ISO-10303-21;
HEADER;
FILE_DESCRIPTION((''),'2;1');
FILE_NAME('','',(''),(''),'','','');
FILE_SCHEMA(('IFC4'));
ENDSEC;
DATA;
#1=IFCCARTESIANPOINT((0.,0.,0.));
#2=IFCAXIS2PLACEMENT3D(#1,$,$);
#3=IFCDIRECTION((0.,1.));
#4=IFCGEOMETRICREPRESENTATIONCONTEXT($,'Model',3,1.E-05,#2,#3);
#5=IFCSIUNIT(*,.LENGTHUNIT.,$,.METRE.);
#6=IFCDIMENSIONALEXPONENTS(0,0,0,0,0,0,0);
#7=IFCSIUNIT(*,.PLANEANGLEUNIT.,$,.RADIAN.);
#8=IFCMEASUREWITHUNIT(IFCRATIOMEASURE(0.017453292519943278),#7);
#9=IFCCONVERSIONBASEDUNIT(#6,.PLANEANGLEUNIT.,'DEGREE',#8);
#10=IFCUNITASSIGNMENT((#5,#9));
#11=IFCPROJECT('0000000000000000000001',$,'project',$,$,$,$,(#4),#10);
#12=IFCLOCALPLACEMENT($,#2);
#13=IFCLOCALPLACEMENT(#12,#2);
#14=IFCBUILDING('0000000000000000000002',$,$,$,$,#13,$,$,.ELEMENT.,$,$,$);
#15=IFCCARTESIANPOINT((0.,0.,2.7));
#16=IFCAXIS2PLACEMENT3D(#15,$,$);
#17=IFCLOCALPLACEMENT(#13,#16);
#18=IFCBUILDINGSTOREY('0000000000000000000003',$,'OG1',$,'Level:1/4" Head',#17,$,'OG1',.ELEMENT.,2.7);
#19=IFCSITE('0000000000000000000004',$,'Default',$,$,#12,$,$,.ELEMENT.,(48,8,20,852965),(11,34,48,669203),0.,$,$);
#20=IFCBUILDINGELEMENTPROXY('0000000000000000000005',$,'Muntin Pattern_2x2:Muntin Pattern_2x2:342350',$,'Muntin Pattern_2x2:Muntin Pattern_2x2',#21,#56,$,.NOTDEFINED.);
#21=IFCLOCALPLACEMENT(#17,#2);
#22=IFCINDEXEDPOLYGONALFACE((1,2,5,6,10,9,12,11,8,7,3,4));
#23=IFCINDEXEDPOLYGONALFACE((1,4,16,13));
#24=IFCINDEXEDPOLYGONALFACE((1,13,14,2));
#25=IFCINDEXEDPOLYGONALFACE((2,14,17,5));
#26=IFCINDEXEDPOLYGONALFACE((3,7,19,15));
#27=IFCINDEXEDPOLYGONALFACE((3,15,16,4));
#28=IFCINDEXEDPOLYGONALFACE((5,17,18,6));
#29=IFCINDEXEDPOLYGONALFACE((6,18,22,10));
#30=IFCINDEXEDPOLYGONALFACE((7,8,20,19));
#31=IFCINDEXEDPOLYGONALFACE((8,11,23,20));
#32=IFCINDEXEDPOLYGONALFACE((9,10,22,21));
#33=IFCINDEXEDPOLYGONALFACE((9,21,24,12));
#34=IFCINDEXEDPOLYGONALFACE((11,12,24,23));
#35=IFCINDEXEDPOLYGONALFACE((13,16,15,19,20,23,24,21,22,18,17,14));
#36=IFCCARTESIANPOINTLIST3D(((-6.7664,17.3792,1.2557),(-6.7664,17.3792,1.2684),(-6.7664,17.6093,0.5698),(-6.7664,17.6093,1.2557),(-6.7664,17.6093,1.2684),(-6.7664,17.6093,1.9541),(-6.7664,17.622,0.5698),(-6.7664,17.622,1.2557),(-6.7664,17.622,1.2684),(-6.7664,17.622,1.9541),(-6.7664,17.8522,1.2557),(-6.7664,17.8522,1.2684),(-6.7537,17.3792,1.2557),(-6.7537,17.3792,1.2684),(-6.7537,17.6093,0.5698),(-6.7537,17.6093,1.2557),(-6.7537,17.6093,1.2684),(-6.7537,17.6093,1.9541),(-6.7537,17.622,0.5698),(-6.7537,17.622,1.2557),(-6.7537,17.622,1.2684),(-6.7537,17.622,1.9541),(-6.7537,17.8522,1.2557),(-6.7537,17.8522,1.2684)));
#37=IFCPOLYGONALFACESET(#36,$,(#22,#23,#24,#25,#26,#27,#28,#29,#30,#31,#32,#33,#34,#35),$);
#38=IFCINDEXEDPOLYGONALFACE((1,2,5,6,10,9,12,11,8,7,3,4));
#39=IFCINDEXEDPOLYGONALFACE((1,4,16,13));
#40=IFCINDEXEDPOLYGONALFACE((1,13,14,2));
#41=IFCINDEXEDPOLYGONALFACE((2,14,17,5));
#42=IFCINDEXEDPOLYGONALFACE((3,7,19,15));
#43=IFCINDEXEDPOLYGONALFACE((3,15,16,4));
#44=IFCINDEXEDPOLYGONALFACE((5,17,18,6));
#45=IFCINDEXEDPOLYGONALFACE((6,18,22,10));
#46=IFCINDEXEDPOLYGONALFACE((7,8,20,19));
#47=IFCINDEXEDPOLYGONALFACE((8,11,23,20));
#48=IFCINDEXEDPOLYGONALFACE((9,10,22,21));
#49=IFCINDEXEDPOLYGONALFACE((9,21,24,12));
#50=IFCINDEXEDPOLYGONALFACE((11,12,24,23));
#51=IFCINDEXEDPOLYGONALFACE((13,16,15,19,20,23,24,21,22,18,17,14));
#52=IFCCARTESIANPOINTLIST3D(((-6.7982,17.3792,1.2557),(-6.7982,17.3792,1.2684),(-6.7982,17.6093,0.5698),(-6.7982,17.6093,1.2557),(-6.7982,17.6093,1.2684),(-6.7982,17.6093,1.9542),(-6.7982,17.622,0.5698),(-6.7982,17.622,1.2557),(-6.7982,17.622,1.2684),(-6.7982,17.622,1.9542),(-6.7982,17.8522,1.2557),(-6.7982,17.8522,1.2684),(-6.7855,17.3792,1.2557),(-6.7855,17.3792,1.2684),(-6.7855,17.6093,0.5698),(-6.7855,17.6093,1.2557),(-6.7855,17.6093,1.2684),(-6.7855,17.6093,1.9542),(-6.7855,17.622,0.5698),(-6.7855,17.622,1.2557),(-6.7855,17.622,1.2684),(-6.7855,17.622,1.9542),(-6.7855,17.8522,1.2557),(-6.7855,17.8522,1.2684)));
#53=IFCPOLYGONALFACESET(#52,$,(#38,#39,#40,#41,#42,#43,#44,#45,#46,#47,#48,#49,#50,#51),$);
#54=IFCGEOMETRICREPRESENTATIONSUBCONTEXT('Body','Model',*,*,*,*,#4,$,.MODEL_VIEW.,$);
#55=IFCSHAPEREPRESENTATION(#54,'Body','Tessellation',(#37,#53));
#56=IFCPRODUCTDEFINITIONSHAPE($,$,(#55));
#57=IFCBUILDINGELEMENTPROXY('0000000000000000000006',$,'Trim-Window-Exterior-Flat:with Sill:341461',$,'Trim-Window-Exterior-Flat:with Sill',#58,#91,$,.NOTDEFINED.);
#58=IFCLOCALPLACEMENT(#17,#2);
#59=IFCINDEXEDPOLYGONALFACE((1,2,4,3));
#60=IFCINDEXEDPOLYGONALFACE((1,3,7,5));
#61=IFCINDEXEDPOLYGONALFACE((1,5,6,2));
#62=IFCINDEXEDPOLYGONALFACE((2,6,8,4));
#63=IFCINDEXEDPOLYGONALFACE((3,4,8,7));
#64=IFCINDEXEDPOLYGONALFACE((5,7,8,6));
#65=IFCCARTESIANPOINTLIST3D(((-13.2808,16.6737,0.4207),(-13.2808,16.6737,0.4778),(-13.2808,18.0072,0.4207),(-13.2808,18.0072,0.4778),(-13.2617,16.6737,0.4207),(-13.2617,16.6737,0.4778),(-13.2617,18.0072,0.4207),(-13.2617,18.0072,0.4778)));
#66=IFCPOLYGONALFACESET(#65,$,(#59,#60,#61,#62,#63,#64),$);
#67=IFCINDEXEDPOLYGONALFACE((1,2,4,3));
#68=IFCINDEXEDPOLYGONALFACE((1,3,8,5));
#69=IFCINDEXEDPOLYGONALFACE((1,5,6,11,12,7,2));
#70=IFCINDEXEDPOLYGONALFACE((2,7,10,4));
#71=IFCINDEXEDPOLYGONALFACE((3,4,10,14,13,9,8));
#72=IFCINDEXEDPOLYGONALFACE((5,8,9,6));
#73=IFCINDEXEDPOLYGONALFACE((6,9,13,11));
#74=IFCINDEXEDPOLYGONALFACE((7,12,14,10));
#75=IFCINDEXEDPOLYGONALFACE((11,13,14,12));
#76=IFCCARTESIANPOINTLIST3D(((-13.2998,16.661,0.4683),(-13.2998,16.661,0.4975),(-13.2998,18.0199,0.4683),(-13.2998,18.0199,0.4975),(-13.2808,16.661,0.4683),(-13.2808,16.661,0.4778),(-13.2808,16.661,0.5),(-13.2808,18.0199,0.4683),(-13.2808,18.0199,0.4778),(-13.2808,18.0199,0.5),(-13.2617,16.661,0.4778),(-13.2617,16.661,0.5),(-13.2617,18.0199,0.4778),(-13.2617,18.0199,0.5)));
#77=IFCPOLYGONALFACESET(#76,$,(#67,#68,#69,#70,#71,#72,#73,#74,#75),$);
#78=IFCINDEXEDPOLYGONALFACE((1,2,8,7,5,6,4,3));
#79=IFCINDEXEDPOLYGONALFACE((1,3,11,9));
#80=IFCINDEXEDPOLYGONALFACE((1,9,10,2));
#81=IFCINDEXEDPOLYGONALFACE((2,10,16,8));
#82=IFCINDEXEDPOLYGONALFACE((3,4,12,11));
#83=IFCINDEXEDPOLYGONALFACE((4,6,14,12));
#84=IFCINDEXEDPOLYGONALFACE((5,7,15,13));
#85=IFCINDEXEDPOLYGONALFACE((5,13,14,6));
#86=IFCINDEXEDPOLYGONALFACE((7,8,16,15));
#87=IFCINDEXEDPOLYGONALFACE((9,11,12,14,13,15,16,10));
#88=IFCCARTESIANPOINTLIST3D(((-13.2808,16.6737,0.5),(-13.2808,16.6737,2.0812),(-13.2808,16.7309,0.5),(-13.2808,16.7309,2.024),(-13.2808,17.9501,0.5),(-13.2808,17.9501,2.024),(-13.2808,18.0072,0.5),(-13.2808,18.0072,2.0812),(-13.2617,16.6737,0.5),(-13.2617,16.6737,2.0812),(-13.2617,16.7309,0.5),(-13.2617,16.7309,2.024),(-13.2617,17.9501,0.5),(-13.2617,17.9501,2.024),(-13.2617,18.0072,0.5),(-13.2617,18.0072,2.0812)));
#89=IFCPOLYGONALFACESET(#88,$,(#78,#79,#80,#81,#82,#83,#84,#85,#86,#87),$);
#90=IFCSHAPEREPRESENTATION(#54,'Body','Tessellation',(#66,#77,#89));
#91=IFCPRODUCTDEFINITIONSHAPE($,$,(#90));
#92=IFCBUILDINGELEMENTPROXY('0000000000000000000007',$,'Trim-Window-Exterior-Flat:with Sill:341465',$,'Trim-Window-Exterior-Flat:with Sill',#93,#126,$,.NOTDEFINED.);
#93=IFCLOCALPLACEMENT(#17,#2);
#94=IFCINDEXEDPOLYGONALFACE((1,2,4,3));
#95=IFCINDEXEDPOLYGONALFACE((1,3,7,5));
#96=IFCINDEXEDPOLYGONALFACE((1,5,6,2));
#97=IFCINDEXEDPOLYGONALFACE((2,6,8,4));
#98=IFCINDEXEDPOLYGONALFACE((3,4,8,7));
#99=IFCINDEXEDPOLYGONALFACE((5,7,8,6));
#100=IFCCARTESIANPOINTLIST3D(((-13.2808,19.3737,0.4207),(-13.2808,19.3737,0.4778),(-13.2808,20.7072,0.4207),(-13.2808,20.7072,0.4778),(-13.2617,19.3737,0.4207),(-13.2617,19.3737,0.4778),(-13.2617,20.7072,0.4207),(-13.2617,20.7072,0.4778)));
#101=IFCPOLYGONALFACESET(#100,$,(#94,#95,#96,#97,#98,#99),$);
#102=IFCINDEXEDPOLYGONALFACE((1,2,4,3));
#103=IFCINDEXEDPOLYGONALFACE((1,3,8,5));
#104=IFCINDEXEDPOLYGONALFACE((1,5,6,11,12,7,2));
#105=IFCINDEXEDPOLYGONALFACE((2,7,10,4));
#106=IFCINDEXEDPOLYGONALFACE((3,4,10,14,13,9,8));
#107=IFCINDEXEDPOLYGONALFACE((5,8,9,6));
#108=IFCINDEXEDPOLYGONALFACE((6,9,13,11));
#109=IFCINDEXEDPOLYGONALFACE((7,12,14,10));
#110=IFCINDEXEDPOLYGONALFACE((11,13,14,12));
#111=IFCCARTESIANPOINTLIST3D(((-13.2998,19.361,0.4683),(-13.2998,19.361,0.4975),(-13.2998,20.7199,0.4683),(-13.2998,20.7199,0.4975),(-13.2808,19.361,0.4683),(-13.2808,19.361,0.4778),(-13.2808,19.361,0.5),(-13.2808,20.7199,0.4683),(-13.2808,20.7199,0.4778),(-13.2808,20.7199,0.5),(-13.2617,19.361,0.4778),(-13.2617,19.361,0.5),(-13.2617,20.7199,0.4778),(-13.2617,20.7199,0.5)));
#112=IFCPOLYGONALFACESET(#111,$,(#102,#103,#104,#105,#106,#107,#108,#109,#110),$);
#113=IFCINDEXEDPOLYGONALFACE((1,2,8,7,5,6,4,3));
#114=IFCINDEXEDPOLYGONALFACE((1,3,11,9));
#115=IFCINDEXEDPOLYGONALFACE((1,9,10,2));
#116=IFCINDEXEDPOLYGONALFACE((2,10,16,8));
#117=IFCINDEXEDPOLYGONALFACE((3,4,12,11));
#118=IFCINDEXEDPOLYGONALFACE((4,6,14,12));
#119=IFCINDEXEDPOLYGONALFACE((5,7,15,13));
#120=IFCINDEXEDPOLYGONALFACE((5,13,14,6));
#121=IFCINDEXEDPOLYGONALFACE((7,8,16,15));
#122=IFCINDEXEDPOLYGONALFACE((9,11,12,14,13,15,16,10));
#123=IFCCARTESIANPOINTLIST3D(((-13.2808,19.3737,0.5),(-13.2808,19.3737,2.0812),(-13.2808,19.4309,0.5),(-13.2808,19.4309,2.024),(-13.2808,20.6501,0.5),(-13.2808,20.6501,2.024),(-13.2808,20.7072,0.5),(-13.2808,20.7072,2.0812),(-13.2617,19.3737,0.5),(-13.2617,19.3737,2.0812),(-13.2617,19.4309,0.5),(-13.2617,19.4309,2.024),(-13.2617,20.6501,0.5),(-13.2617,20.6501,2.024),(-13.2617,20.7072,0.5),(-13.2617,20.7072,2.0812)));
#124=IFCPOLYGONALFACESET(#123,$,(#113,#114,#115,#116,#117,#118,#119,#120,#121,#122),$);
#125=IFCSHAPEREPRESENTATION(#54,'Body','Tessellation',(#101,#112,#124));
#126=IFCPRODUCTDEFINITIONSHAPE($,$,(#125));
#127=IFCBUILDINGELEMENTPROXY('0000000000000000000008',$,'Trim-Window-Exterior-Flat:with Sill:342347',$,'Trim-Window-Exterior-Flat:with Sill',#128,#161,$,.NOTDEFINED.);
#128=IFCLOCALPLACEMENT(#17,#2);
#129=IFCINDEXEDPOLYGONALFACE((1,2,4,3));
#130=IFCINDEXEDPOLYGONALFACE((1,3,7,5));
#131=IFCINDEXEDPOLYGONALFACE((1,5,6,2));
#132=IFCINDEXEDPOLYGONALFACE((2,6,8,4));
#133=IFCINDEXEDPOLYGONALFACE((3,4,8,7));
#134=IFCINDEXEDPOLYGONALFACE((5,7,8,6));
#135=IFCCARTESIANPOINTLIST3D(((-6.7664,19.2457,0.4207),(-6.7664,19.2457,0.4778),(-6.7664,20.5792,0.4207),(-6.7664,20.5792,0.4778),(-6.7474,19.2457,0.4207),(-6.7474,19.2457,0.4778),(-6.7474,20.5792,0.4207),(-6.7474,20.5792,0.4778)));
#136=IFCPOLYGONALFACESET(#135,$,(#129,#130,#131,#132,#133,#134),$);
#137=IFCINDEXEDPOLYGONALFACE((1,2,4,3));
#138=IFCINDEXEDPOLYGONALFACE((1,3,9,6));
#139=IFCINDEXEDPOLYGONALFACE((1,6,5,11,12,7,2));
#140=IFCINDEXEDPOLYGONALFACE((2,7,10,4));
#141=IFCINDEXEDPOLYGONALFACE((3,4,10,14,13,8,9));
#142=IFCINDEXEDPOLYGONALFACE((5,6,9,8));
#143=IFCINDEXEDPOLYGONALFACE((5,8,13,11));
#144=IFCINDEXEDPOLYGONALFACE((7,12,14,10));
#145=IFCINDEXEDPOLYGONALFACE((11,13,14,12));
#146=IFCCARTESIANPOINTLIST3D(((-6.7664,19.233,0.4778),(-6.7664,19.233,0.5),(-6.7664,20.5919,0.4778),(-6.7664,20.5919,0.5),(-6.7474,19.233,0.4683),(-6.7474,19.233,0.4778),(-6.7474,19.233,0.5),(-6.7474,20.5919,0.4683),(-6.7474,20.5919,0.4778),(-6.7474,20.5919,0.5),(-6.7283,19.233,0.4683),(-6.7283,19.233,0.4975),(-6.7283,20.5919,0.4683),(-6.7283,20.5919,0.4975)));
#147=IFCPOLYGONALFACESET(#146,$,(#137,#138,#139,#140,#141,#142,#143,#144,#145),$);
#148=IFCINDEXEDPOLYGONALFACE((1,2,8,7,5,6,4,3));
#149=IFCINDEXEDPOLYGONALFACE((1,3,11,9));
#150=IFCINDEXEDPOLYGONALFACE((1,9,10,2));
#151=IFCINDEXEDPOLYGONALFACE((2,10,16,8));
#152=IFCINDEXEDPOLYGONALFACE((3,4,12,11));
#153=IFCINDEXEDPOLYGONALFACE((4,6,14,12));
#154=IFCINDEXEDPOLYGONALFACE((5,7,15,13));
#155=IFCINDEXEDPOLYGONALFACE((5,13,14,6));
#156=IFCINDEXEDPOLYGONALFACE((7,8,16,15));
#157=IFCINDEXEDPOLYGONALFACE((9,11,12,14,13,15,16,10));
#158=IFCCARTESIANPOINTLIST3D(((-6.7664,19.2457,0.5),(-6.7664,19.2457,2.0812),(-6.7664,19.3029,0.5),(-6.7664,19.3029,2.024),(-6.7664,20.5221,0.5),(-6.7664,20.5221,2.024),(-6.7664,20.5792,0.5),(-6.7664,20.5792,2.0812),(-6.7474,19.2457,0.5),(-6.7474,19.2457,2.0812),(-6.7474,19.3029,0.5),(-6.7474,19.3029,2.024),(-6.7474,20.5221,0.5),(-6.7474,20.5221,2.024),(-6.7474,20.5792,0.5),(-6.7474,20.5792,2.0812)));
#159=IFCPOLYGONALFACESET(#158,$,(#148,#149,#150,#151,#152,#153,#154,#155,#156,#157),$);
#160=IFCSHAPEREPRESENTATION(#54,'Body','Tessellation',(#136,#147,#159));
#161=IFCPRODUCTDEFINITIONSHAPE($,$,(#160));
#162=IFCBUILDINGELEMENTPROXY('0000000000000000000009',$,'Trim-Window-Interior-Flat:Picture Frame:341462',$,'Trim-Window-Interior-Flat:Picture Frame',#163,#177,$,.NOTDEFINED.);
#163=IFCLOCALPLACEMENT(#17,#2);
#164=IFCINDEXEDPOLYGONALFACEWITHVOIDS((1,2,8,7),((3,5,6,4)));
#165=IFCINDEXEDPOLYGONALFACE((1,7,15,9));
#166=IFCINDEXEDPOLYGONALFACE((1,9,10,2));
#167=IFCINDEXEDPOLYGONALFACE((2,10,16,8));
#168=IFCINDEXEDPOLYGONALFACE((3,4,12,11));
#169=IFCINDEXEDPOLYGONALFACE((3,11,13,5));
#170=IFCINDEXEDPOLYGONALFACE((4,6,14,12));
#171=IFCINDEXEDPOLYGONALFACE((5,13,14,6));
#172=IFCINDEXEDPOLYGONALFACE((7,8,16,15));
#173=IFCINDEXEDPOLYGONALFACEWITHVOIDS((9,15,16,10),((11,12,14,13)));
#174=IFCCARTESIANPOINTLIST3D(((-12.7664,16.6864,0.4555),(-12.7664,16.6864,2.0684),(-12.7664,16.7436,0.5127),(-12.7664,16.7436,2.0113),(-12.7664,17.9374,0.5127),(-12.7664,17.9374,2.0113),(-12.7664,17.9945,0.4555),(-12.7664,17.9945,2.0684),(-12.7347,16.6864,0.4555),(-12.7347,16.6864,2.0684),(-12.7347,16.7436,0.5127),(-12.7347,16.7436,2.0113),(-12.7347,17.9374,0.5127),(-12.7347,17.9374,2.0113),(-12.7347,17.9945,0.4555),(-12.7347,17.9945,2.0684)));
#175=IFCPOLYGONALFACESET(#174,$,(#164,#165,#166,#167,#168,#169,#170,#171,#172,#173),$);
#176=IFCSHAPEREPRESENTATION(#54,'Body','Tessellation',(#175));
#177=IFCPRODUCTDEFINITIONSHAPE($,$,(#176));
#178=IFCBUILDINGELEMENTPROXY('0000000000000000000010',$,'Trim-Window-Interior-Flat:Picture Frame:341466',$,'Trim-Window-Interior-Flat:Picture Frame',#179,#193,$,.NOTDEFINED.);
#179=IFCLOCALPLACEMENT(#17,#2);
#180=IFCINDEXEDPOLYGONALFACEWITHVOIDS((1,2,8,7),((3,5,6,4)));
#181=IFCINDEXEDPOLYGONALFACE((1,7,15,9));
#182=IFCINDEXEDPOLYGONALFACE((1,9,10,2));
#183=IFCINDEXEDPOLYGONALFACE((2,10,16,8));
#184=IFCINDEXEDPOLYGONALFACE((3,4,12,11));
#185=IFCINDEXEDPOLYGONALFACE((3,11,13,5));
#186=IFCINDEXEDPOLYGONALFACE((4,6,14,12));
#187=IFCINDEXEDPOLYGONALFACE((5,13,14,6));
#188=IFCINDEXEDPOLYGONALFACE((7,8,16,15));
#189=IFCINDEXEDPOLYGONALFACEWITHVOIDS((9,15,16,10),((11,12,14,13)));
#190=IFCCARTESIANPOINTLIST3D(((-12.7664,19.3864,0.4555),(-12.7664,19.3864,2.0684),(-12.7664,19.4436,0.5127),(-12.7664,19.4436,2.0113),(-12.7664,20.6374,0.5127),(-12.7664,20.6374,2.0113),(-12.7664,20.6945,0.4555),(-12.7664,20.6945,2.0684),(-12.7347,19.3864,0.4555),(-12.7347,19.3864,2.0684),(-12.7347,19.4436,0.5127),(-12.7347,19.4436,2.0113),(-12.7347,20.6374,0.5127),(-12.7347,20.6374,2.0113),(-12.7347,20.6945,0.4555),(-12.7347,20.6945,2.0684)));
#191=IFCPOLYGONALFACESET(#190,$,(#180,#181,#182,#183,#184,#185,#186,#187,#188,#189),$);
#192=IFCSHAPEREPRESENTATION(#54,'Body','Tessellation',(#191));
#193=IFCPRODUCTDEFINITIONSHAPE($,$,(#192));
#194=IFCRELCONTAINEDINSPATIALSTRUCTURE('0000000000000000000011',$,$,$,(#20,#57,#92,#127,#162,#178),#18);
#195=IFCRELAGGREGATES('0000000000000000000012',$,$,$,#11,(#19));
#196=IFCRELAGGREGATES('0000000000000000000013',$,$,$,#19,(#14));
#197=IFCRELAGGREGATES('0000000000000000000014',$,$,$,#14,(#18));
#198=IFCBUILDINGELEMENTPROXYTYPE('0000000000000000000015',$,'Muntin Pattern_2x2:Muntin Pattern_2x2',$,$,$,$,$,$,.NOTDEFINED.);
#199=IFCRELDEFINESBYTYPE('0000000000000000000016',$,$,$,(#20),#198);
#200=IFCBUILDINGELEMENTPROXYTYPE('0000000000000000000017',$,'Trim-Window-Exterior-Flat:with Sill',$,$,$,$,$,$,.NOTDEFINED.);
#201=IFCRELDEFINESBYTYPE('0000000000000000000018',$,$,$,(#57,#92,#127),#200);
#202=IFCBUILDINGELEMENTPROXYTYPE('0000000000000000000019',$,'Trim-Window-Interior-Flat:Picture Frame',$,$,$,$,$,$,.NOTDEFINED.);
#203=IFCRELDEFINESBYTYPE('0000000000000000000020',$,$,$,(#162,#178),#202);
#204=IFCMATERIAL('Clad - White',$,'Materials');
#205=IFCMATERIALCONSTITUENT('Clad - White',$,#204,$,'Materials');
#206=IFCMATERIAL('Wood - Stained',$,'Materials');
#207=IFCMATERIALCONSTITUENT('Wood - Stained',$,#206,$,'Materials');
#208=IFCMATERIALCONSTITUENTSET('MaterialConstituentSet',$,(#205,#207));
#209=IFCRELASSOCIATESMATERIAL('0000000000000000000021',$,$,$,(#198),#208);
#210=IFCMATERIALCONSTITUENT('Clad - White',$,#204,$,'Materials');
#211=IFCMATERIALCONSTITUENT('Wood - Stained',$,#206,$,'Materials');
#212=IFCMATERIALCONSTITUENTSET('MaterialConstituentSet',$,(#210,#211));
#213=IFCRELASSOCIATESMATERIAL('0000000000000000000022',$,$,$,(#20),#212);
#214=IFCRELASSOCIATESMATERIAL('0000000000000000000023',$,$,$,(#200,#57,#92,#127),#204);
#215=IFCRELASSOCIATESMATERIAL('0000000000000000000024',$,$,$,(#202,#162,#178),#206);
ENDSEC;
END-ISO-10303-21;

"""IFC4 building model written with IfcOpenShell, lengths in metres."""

from ifc_helpers import new_model, entity, si_unit, converted_unit, direction, frame, origin, place, context, subcontext, project, spatial, indexed_curve, outline, extrude, source, transform, mapped, material, constituent, constituent_set, type_object, type_shapes, element, save


model = new_model("IFC4")

# Units and contexts
model_context = context("Model", 3, precision=1e-05, world=origin(), true_north=direction((0.0, 1.0)))
body_context = subcontext(model_context, "Body", "Model", "MODEL_VIEW")
ifc_project = project(units=[si_unit("LENGTHUNIT", "METRE"), converted_unit("PLANEANGLEUNIT", "DEGREE", entity("IfcRatioMeasure", 0.017453292519943278), si_unit("PLANEANGLEUNIT", "RADIAN"), dimensions=[0, 0, 0, 0, 0, 0, 0])], contexts=[model_context])

# Site, building, storey
site_placement = place(None, origin())
site = spatial("IfcSite", under=ifc_project, at=site_placement, Name="Default", CompositionType="ELEMENT", RefLatitude=(48, 8, 20, 852965), RefLongitude=(11, 34, 48, 669203), RefElevation=0.0)
building_placement = place(site_placement, origin())
building = spatial("IfcBuilding", under=site, at=building_placement, CompositionType="ELEMENT")
storey_placement = place(building_placement, frame((0.0, 0.0, 2.7)))
storey = spatial("IfcBuildingStorey", under=building, at=storey_placement, Name="OG1", ObjectType="Level:1/4\" Head", LongName="OG1", CompositionType="ELEMENT", Elevation=2.7)

# Building element proxies
ifc_material_1 = material(Name="Clad - White", Category="Materials")
ifc_material_2 = material(Name="Wood - Stained", Category="Materials")
ifc_constituent_1 = constituent(ifc_material_1, Name="Clad - White", Category="Materials")
ifc_constituent_2 = constituent(ifc_material_2, Name="Wood - Stained", Category="Materials")
ifc_constituent_set_1 = constituent_set(constituents=[ifc_constituent_1, ifc_constituent_2], Name="MaterialConstituentSet")
building_element_proxy_type_1 = type_object("IfcBuildingElementProxyType", Name="Muntin Pattern_2x2:Muntin Pattern_2x2", PredefinedType="NOTDEFINED", material=ifc_constituent_set_1)
shared_shape_1 = source(origin(), body_context, "Body", "SweptSolid", [
    extrude(outline(indexed_curve([(0.0064, -0.0064), (0.6921, -0.0064), (0.6921, 0.0063), (0.0064, 0.0063), (0.0064, 0.2365), (-0.0063, 0.2365), (-0.0063, 0.0063), (-0.6922, 0.0063), (-0.6922, -0.0064), (-0.0063, -0.0064), (-0.0063, -0.2365), (0.0064, -0.2365), (0.0064, -0.0064)], self_intersect=False)), frame((0.0, 0.0095, 0.6921), z_axis=(0.0, 1.0, 0.0), x_axis=(0.0, 0.0, 1.0)), (0.0, 0.0, 1.0), 0.0127),
    extrude(outline(indexed_curve([(0.0064, -0.0064), (0.6922, -0.0064), (0.6922, 0.0063), (0.0064, 0.0063), (0.0064, 0.2365), (-0.0063, 0.2365), (-0.0063, 0.0063), (-0.6922, 0.0063), (-0.6922, -0.0064), (-0.0063, -0.0064), (-0.0063, -0.2365), (0.0064, -0.2365), (0.0064, -0.0064)], self_intersect=False)), frame((0.0, -0.0222, 0.6922), z_axis=(0.0, 1.0, 0.0), x_axis=(0.0, 0.0, 1.0)), (0.0, 0.0, 1.0), 0.0127),
])
type_shapes(building_element_proxy_type_1, [shared_shape_1])
ifc_constituent_3 = constituent(ifc_material_1, Name="Clad - White", Category="Materials")
ifc_constituent_4 = constituent(ifc_material_2, Name="Wood - Stained", Category="Materials")
ifc_constituent_set_2 = constituent_set(constituents=[ifc_constituent_3, ifc_constituent_4], Name="MaterialConstituentSet")
proxy_1_placement = place(storey_placement, frame((-6.7759, 17.6157, 0.5699), z_axis=(0.0, 0.0, 1.0), x_axis=(0.0, -1.0, 0.0)))
element("IfcBuildingElementProxy", 1, at=proxy_1_placement, inside=storey, type_object=building_element_proxy_type_1, material=ifc_constituent_set_2, Name="Muntin Pattern_2x2:Muntin Pattern_2x2:342350", ObjectType="Muntin Pattern_2x2:Muntin Pattern_2x2", PredefinedType="NOTDEFINED", context=body_context, shape_type="MappedRepresentation", body=[
    mapped(shared_shape_1, transform((0.0, 0.0, 0.0), scale=1.0)),
])
building_element_proxy_type_2 = type_object("IfcBuildingElementProxyType", Name="Trim-Window-Exterior-Flat:with Sill", PredefinedType="NOTDEFINED", material=ifc_material_1)
shared_shape_2 = source(origin(), body_context, "Body", "SweptSolid", [
    extrude(outline(indexed_curve([(-0.6667, -0.0286), (0.6667, -0.0286), (0.6667, 0.0286), (-0.6667, 0.0286), (-0.6667, -0.0286)], self_intersect=False)), frame((0.0, -1.5748, 0.0), z_axis=(0.0, 0.0, 1.0), x_axis=(-1.0, 0.0, 0.0)), (0.0, 0.0, 1.0), 0.019),
    extrude(outline(indexed_curve([(-0.019, -0.016), (0.0, -0.016), (0.0, -0.0064), (0.019, -0.0064), (0.019, 0.0158), (0.0, 0.0158), (-0.019, 0.0133), (-0.019, -0.016)], self_intersect=False)), frame((-0.6794, -1.5398, 0.019), z_axis=(1.0, 0.0, 0.0), x_axis=(0.0, 0.0, -1.0)), (0.0, 0.0, 1.0), 1.3589),
    extrude(outline(indexed_curve([(-0.8049, -0.6667), (0.7763, -0.6667), (0.7763, -0.6096), (-0.7477, -0.6096), (-0.7477, 0.6096), (0.7763, 0.6096), (0.7763, 0.6667), (-0.8049, 0.6667), (-0.8049, -0.6667)], self_intersect=False)), frame((0.0, -0.7477, 0.0), z_axis=(0.0, 0.0, 1.0), x_axis=(0.0, -1.0, 0.0)), (0.0, 0.0, 1.0), 0.019),
])
type_shapes(building_element_proxy_type_2, [shared_shape_2])
for number, where, z_axis, x_axis, name in (
    (2, (-13.2617, 17.3405, 2.024), (-1.0, 0.0, 0.0), (0.0, -1.0, 0.0), "Trim-Window-Exterior-Flat:with Sill:341461"),
    (3, (-13.2617, 20.0405, 2.024), (-1.0, 0.0, 0.0), (0.0, -1.0, 0.0), "Trim-Window-Exterior-Flat:with Sill:341465"),
    (4, (-6.7664, 19.9125, 2.024), (1.0, 0.0, 0.0), (0.0, 1.0, 0.0), "Trim-Window-Exterior-Flat:with Sill:342347"),
):
    element("IfcBuildingElementProxy", number, at=place(storey_placement, frame(where, z_axis=z_axis, x_axis=x_axis)), inside=storey, type_object=building_element_proxy_type_2, material=ifc_material_1, Name=name, ObjectType="Trim-Window-Exterior-Flat:with Sill", PredefinedType="NOTDEFINED", context=body_context, shape_type="MappedRepresentation", body=[
        mapped(shared_shape_2, transform((0.0, 0.0, 0.0), scale=1.0)),
    ])
building_element_proxy_type_3 = type_object("IfcBuildingElementProxyType", Name="Trim-Window-Interior-Flat:Picture Frame", PredefinedType="NOTDEFINED", material=ifc_material_2)
shared_shape_3 = source(origin(), body_context, "Body", "SweptSolid", [
    extrude(outline(indexed_curve([(-0.654, -0.8064), (0.654, -0.8064), (0.654, 0.8064), (-0.654, 0.8064), (-0.654, -0.8064)], self_intersect=False), holes=[indexed_curve([(-0.5969, -0.7493), (-0.5969, 0.7493), (0.5969, 0.7493), (0.5969, -0.7493), (-0.5969, -0.7493)], self_intersect=False)]), frame((0.0, -0.762, 0.0), z_axis=(0.0, 0.0, 1.0), x_axis=(-1.0, 0.0, 0.0)), (0.0, 0.0, 1.0), 0.0317),
])
type_shapes(building_element_proxy_type_3, [shared_shape_3])
for number, where, z_axis, x_axis, name in (
    (5, (-12.7664, 17.3405, 2.024), (1.0, 0.0, 0.0), (0.0, 1.0, 0.0), "Trim-Window-Interior-Flat:Picture Frame:341462"),
    (6, (-12.7664, 20.0405, 2.024), (1.0, 0.0, 0.0), (0.0, 1.0, 0.0), "Trim-Window-Interior-Flat:Picture Frame:341466"),
):
    element("IfcBuildingElementProxy", number, at=place(storey_placement, frame(where, z_axis=z_axis, x_axis=x_axis)), inside=storey, type_object=building_element_proxy_type_3, material=ifc_material_2, Name=name, ObjectType="Trim-Window-Interior-Flat:Picture Frame", PredefinedType="NOTDEFINED", context=body_context, shape_type="MappedRepresentation", body=[
        mapped(shared_shape_3, transform((0.0, 0.0, 0.0), scale=1.0)),
    ])

save(model, "model.ifc")
